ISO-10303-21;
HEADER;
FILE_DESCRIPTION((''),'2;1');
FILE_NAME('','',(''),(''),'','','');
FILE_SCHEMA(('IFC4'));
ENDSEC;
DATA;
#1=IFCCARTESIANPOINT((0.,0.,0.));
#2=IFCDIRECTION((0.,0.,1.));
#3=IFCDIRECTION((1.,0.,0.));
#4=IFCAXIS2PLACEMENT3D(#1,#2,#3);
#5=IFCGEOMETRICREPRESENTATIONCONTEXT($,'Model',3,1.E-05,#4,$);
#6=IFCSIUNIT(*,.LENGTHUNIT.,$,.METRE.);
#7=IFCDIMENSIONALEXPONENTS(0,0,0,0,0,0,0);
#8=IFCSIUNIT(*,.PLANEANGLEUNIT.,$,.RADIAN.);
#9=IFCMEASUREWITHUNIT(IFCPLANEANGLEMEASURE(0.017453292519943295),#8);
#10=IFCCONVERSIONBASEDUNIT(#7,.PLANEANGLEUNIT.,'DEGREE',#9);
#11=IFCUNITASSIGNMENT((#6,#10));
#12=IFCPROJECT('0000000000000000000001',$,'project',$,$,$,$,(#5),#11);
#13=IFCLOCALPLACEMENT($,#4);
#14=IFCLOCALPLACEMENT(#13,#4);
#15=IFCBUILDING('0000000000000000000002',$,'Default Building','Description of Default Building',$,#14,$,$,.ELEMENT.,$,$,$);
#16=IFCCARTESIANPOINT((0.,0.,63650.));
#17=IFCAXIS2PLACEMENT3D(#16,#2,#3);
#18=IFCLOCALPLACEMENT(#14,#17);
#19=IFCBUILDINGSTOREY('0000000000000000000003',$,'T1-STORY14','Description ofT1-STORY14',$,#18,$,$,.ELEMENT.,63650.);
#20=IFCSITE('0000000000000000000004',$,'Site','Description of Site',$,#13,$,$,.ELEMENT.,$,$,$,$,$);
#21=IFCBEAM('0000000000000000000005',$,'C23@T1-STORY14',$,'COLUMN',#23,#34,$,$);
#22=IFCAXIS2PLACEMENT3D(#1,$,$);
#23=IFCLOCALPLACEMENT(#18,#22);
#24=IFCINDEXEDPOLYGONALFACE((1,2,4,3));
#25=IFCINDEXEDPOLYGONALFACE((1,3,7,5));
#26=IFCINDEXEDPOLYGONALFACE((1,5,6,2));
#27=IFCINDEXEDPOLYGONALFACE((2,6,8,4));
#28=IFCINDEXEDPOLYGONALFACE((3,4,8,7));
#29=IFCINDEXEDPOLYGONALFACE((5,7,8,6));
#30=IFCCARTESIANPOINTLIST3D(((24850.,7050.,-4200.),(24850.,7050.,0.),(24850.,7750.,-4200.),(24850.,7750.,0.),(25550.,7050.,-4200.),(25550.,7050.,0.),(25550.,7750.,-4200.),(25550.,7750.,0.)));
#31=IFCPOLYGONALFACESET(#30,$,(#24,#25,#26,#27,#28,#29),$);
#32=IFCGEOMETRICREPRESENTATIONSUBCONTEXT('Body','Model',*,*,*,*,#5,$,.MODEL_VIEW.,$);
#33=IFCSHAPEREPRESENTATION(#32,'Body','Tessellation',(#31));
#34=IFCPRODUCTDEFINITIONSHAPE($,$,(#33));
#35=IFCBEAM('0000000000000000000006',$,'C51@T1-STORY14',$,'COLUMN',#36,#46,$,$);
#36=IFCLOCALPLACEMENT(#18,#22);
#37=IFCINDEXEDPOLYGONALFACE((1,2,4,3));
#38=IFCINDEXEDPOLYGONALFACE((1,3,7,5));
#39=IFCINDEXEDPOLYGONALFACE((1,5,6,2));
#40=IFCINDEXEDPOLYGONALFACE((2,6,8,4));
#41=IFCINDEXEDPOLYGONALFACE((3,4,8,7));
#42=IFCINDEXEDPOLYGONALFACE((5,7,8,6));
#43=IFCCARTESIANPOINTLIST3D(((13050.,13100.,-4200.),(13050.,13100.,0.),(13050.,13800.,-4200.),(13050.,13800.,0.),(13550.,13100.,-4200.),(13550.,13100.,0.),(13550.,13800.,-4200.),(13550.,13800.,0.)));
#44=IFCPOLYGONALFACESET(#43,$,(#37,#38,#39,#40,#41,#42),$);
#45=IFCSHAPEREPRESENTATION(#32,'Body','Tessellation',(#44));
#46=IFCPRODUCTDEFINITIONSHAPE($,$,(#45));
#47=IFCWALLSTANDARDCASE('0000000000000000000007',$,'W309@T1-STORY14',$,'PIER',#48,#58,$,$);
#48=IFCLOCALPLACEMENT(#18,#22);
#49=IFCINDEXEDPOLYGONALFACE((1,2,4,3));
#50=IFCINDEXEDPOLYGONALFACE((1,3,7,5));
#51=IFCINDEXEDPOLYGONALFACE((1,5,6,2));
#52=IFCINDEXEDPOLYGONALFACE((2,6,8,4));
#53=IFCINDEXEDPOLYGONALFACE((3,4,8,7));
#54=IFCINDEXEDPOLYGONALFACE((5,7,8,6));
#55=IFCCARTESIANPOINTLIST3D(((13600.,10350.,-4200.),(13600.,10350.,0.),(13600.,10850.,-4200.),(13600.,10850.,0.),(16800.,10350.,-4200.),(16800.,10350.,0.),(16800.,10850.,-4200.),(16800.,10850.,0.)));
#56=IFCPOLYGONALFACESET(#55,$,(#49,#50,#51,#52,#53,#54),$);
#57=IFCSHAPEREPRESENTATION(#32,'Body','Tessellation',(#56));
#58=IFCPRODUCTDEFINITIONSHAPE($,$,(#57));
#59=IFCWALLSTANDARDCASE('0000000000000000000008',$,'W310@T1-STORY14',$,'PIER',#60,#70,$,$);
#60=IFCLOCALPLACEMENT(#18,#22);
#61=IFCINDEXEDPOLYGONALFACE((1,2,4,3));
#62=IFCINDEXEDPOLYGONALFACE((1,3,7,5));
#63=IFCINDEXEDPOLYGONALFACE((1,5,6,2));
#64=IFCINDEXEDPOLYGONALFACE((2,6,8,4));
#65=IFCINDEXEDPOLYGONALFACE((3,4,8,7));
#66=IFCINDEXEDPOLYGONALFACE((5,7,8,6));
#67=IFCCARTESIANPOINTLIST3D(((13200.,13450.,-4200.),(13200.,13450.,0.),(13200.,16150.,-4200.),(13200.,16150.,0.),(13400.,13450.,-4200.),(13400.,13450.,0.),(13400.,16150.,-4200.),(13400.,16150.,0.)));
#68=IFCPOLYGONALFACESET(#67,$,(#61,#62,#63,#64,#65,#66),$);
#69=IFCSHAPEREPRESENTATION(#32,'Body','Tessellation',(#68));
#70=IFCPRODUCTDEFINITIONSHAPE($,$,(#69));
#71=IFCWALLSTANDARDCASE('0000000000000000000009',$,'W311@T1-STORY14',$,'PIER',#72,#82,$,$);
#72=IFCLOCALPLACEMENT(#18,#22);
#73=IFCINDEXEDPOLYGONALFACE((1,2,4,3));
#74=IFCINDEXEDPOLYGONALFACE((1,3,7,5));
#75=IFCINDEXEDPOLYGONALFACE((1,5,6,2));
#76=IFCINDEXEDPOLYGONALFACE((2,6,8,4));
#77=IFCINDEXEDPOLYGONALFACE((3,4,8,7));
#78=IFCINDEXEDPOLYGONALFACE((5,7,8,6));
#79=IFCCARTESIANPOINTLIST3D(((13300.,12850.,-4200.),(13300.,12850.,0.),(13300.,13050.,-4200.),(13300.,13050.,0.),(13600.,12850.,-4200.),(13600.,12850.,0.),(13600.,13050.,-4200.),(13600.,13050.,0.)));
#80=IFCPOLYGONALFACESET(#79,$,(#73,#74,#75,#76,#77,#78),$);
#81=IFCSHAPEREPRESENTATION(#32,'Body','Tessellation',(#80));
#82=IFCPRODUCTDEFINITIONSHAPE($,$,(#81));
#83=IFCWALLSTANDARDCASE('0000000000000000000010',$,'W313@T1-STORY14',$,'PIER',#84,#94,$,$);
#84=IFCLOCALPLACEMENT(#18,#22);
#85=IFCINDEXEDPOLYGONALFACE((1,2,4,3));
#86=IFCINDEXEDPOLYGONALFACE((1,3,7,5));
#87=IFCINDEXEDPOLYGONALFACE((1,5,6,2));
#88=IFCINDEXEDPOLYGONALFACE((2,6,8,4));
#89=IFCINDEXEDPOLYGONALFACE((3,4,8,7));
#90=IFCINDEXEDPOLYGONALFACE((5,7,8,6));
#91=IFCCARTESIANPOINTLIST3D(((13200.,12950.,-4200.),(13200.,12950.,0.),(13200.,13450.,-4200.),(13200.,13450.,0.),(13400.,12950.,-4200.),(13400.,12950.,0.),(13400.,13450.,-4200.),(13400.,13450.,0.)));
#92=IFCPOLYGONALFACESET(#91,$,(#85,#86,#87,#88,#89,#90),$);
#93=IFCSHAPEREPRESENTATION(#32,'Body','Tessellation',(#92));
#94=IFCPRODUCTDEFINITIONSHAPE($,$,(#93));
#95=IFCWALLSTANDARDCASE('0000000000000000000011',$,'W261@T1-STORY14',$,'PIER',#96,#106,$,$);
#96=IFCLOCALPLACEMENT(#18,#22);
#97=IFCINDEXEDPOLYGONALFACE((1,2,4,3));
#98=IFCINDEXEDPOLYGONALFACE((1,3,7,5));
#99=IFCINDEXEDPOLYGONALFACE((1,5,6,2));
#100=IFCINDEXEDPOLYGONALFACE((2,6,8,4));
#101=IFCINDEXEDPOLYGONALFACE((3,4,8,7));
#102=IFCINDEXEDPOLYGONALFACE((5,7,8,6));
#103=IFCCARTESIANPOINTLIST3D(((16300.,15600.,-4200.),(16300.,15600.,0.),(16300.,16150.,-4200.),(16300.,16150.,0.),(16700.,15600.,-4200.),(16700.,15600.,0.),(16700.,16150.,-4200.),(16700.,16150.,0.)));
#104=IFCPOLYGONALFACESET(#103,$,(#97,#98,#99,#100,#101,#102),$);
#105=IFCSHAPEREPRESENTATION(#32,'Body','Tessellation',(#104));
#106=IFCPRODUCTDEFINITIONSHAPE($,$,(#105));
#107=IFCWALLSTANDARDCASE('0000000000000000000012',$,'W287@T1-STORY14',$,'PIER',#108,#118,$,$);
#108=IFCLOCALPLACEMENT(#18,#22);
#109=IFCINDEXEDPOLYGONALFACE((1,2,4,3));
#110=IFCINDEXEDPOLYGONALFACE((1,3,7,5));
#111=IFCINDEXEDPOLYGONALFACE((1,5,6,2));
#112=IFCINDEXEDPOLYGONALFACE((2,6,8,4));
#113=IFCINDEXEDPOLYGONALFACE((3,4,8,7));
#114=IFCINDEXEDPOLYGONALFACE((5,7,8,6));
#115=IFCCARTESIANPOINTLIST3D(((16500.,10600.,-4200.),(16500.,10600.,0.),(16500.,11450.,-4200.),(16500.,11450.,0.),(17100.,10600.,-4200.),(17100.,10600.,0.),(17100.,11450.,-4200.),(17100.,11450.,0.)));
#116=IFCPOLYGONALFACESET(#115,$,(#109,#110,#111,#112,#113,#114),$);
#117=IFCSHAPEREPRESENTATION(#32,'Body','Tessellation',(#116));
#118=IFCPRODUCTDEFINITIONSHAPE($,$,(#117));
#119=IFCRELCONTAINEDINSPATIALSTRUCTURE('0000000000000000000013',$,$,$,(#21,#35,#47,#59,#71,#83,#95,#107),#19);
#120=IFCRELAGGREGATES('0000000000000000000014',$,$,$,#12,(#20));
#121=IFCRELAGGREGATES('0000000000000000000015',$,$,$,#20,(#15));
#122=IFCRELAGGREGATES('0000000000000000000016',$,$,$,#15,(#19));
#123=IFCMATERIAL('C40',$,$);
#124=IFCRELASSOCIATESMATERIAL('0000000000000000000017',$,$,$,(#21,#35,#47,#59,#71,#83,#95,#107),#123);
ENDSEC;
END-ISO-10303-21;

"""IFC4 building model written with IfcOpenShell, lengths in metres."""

from ifc_helpers import new_model, entity, si_unit, converted_unit, frame, origin_with_axes, place, context, subcontext, project, spatial, indexed_curve, rectangle, outline, extrude, material, element, save


model = new_model("IFC4")

# Units and contexts
model_context = context("Model", 3, precision=1e-05, world=origin_with_axes())
body_context = subcontext(model_context, "Body", "Model", "MODEL_VIEW")
ifc_project = project(units=[si_unit("LENGTHUNIT", "METRE"), converted_unit("PLANEANGLEUNIT", "DEGREE", entity("IfcPlaneAngleMeasure", 0.017453292519943295), si_unit("PLANEANGLEUNIT", "RADIAN"), dimensions=[0, 0, 0, 0, 0, 0, 0])], contexts=[model_context])

# Site, building, storey
site_placement = place(None, origin_with_axes())
site = spatial("IfcSite", under=ifc_project, at=site_placement, Name="Site", Description="Description of Site", CompositionType="ELEMENT")
building_placement = place(site_placement, origin_with_axes())
building = spatial("IfcBuilding", under=site, at=building_placement, Name="Default Building", Description="Description of Default Building", CompositionType="ELEMENT")
storey_placement = place(building_placement, frame((0.0, 0.0, 63650.0), z_axis=(0.0, 0.0, 1.0), x_axis=(1.0, 0.0, 0.0)))
storey = spatial("IfcBuildingStorey", under=building, at=storey_placement, Name="T1-STORY14", Description="Description ofT1-STORY14", CompositionType="ELEMENT", Elevation=63650.0)

# Beams
ifc_material_1 = material(Name="C40")
beam_1_placement = place(storey_placement, frame((25200.0, 7400.0, -4200.0), z_axis=(0.0, 0.0, 1.0), x_axis=(-1.0, 0.0, 0.0)))
element("IfcBeam", 1, at=beam_1_placement, inside=storey, material=ifc_material_1, Name="C23@T1-STORY14", ObjectType="COLUMN", context=body_context, shape_type="SweptSolid", body=[
    extrude(rectangle(XDim=700.0, YDim=700.0), origin_with_axes(), (0.0, 0.0, 1.0), 4200.0),
])
beam_2_placement = place(storey_placement, frame((13300.0, 13450.0, -4200.0), z_axis=(0.0, 0.0, 1.0), x_axis=(-1.0, 0.0, 0.0)))
element("IfcBeam", 2, at=beam_2_placement, inside=storey, material=ifc_material_1, Name="C51@T1-STORY14", ObjectType="COLUMN", context=body_context, shape_type="SweptSolid", body=[
    extrude(rectangle(XDim=500.0, YDim=700.0), origin_with_axes(), (0.0, 0.0, 1.0), 4200.0),
])

# Walls
wall_1_placement = place(storey_placement, frame((13600.0, 10600.0, -4200.0), z_axis=(0.0, 0.0, 1.0), x_axis=(1.0, 0.0, 0.0)))
element("IfcWallStandardCase", 3, at=wall_1_placement, inside=storey, material=ifc_material_1, Name="W309@T1-STORY14", ObjectType="PIER", context=body_context, shape_type="SweptSolid", body=[
    extrude(outline(indexed_curve([(0.0, -250.0), (0.0, 250.0), (3200.0, 250.0), (3200.0, -250.0), (0.0, -250.0)], self_intersect=False)), origin_with_axes(), (0.0, 0.0, 1.0), 4200.0),
])
wall_2_placement = place(storey_placement, frame((13300.0, 13450.0, -4200.0), z_axis=(0.0, 0.0, 1.0), x_axis=(0.0, 1.0, 0.0)))
element("IfcWallStandardCase", 4, at=wall_2_placement, inside=storey, material=ifc_material_1, Name="W310@T1-STORY14", ObjectType="PIER", context=body_context, shape_type="SweptSolid", body=[
    extrude(outline(indexed_curve([(0.0, -100.0), (0.0, 100.0), (2700.0, 100.0), (2700.0, -100.0), (0.0, -100.0)], self_intersect=False)), origin_with_axes(), (0.0, 0.0, 1.0), 4200.0),
])
wall_3_placement = place(storey_placement, frame((13300.0, 12950.0, -4200.0), z_axis=(0.0, 0.0, 1.0), x_axis=(1.0, 0.0, 0.0)))
element("IfcWallStandardCase", 5, at=wall_3_placement, inside=storey, material=ifc_material_1, Name="W311@T1-STORY14", ObjectType="PIER", context=body_context, shape_type="SweptSolid", body=[
    extrude(outline(indexed_curve([(0.0, -100.0), (0.0, 100.0), (300.0, 100.0), (300.0, -100.0), (0.0, -100.0)], self_intersect=False)), origin_with_axes(), (0.0, 0.0, 1.0), 4200.0),
])
wall_4_placement = place(storey_placement, frame((13300.0, 12950.0, -4200.0), z_axis=(0.0, 0.0, 1.0), x_axis=(0.0, 1.0, 0.0)))
element("IfcWallStandardCase", 6, at=wall_4_placement, inside=storey, material=ifc_material_1, Name="W313@T1-STORY14", ObjectType="PIER", context=body_context, shape_type="SweptSolid", body=[
    extrude(outline(indexed_curve([(0.0, -100.0), (0.0, 100.0), (500.0, 100.0), (500.0, -100.0), (0.0, -100.0)], self_intersect=False)), origin_with_axes(), (0.0, 0.0, 1.0), 4200.0),
])
wall_5_placement = place(storey_placement, frame((16500.0, 15600.0, -4200.0), z_axis=(0.0, 0.0, 1.0), x_axis=(0.0, 1.0, 0.0)))
element("IfcWallStandardCase", 7, at=wall_5_placement, inside=storey, material=ifc_material_1, Name="W261@T1-STORY14", ObjectType="PIER", context=body_context, shape_type="SweptSolid", body=[
    extrude(outline(indexed_curve([(0.0, -200.0), (0.0, 200.0), (550.0, 200.0), (550.0, -200.0), (0.0, -200.0)], self_intersect=False)), origin_with_axes(), (0.0, 0.0, 1.0), 4200.0),
])
wall_6_placement = place(storey_placement, frame((16800.0, 10600.0, -4200.0), z_axis=(0.0, 0.0, 1.0), x_axis=(0.0, 1.0, 0.0)))
element("IfcWallStandardCase", 8, at=wall_6_placement, inside=storey, material=ifc_material_1, Name="W287@T1-STORY14", ObjectType="PIER", context=body_context, shape_type="SweptSolid", body=[
    extrude(outline(indexed_curve([(0.0, -300.0), (0.0, 300.0), (850.0, 300.0), (850.0, -300.0), (0.0, -300.0)], self_intersect=False)), origin_with_axes(), (0.0, 0.0, 1.0), 4200.0),
])

save(model, "model.ifc")
